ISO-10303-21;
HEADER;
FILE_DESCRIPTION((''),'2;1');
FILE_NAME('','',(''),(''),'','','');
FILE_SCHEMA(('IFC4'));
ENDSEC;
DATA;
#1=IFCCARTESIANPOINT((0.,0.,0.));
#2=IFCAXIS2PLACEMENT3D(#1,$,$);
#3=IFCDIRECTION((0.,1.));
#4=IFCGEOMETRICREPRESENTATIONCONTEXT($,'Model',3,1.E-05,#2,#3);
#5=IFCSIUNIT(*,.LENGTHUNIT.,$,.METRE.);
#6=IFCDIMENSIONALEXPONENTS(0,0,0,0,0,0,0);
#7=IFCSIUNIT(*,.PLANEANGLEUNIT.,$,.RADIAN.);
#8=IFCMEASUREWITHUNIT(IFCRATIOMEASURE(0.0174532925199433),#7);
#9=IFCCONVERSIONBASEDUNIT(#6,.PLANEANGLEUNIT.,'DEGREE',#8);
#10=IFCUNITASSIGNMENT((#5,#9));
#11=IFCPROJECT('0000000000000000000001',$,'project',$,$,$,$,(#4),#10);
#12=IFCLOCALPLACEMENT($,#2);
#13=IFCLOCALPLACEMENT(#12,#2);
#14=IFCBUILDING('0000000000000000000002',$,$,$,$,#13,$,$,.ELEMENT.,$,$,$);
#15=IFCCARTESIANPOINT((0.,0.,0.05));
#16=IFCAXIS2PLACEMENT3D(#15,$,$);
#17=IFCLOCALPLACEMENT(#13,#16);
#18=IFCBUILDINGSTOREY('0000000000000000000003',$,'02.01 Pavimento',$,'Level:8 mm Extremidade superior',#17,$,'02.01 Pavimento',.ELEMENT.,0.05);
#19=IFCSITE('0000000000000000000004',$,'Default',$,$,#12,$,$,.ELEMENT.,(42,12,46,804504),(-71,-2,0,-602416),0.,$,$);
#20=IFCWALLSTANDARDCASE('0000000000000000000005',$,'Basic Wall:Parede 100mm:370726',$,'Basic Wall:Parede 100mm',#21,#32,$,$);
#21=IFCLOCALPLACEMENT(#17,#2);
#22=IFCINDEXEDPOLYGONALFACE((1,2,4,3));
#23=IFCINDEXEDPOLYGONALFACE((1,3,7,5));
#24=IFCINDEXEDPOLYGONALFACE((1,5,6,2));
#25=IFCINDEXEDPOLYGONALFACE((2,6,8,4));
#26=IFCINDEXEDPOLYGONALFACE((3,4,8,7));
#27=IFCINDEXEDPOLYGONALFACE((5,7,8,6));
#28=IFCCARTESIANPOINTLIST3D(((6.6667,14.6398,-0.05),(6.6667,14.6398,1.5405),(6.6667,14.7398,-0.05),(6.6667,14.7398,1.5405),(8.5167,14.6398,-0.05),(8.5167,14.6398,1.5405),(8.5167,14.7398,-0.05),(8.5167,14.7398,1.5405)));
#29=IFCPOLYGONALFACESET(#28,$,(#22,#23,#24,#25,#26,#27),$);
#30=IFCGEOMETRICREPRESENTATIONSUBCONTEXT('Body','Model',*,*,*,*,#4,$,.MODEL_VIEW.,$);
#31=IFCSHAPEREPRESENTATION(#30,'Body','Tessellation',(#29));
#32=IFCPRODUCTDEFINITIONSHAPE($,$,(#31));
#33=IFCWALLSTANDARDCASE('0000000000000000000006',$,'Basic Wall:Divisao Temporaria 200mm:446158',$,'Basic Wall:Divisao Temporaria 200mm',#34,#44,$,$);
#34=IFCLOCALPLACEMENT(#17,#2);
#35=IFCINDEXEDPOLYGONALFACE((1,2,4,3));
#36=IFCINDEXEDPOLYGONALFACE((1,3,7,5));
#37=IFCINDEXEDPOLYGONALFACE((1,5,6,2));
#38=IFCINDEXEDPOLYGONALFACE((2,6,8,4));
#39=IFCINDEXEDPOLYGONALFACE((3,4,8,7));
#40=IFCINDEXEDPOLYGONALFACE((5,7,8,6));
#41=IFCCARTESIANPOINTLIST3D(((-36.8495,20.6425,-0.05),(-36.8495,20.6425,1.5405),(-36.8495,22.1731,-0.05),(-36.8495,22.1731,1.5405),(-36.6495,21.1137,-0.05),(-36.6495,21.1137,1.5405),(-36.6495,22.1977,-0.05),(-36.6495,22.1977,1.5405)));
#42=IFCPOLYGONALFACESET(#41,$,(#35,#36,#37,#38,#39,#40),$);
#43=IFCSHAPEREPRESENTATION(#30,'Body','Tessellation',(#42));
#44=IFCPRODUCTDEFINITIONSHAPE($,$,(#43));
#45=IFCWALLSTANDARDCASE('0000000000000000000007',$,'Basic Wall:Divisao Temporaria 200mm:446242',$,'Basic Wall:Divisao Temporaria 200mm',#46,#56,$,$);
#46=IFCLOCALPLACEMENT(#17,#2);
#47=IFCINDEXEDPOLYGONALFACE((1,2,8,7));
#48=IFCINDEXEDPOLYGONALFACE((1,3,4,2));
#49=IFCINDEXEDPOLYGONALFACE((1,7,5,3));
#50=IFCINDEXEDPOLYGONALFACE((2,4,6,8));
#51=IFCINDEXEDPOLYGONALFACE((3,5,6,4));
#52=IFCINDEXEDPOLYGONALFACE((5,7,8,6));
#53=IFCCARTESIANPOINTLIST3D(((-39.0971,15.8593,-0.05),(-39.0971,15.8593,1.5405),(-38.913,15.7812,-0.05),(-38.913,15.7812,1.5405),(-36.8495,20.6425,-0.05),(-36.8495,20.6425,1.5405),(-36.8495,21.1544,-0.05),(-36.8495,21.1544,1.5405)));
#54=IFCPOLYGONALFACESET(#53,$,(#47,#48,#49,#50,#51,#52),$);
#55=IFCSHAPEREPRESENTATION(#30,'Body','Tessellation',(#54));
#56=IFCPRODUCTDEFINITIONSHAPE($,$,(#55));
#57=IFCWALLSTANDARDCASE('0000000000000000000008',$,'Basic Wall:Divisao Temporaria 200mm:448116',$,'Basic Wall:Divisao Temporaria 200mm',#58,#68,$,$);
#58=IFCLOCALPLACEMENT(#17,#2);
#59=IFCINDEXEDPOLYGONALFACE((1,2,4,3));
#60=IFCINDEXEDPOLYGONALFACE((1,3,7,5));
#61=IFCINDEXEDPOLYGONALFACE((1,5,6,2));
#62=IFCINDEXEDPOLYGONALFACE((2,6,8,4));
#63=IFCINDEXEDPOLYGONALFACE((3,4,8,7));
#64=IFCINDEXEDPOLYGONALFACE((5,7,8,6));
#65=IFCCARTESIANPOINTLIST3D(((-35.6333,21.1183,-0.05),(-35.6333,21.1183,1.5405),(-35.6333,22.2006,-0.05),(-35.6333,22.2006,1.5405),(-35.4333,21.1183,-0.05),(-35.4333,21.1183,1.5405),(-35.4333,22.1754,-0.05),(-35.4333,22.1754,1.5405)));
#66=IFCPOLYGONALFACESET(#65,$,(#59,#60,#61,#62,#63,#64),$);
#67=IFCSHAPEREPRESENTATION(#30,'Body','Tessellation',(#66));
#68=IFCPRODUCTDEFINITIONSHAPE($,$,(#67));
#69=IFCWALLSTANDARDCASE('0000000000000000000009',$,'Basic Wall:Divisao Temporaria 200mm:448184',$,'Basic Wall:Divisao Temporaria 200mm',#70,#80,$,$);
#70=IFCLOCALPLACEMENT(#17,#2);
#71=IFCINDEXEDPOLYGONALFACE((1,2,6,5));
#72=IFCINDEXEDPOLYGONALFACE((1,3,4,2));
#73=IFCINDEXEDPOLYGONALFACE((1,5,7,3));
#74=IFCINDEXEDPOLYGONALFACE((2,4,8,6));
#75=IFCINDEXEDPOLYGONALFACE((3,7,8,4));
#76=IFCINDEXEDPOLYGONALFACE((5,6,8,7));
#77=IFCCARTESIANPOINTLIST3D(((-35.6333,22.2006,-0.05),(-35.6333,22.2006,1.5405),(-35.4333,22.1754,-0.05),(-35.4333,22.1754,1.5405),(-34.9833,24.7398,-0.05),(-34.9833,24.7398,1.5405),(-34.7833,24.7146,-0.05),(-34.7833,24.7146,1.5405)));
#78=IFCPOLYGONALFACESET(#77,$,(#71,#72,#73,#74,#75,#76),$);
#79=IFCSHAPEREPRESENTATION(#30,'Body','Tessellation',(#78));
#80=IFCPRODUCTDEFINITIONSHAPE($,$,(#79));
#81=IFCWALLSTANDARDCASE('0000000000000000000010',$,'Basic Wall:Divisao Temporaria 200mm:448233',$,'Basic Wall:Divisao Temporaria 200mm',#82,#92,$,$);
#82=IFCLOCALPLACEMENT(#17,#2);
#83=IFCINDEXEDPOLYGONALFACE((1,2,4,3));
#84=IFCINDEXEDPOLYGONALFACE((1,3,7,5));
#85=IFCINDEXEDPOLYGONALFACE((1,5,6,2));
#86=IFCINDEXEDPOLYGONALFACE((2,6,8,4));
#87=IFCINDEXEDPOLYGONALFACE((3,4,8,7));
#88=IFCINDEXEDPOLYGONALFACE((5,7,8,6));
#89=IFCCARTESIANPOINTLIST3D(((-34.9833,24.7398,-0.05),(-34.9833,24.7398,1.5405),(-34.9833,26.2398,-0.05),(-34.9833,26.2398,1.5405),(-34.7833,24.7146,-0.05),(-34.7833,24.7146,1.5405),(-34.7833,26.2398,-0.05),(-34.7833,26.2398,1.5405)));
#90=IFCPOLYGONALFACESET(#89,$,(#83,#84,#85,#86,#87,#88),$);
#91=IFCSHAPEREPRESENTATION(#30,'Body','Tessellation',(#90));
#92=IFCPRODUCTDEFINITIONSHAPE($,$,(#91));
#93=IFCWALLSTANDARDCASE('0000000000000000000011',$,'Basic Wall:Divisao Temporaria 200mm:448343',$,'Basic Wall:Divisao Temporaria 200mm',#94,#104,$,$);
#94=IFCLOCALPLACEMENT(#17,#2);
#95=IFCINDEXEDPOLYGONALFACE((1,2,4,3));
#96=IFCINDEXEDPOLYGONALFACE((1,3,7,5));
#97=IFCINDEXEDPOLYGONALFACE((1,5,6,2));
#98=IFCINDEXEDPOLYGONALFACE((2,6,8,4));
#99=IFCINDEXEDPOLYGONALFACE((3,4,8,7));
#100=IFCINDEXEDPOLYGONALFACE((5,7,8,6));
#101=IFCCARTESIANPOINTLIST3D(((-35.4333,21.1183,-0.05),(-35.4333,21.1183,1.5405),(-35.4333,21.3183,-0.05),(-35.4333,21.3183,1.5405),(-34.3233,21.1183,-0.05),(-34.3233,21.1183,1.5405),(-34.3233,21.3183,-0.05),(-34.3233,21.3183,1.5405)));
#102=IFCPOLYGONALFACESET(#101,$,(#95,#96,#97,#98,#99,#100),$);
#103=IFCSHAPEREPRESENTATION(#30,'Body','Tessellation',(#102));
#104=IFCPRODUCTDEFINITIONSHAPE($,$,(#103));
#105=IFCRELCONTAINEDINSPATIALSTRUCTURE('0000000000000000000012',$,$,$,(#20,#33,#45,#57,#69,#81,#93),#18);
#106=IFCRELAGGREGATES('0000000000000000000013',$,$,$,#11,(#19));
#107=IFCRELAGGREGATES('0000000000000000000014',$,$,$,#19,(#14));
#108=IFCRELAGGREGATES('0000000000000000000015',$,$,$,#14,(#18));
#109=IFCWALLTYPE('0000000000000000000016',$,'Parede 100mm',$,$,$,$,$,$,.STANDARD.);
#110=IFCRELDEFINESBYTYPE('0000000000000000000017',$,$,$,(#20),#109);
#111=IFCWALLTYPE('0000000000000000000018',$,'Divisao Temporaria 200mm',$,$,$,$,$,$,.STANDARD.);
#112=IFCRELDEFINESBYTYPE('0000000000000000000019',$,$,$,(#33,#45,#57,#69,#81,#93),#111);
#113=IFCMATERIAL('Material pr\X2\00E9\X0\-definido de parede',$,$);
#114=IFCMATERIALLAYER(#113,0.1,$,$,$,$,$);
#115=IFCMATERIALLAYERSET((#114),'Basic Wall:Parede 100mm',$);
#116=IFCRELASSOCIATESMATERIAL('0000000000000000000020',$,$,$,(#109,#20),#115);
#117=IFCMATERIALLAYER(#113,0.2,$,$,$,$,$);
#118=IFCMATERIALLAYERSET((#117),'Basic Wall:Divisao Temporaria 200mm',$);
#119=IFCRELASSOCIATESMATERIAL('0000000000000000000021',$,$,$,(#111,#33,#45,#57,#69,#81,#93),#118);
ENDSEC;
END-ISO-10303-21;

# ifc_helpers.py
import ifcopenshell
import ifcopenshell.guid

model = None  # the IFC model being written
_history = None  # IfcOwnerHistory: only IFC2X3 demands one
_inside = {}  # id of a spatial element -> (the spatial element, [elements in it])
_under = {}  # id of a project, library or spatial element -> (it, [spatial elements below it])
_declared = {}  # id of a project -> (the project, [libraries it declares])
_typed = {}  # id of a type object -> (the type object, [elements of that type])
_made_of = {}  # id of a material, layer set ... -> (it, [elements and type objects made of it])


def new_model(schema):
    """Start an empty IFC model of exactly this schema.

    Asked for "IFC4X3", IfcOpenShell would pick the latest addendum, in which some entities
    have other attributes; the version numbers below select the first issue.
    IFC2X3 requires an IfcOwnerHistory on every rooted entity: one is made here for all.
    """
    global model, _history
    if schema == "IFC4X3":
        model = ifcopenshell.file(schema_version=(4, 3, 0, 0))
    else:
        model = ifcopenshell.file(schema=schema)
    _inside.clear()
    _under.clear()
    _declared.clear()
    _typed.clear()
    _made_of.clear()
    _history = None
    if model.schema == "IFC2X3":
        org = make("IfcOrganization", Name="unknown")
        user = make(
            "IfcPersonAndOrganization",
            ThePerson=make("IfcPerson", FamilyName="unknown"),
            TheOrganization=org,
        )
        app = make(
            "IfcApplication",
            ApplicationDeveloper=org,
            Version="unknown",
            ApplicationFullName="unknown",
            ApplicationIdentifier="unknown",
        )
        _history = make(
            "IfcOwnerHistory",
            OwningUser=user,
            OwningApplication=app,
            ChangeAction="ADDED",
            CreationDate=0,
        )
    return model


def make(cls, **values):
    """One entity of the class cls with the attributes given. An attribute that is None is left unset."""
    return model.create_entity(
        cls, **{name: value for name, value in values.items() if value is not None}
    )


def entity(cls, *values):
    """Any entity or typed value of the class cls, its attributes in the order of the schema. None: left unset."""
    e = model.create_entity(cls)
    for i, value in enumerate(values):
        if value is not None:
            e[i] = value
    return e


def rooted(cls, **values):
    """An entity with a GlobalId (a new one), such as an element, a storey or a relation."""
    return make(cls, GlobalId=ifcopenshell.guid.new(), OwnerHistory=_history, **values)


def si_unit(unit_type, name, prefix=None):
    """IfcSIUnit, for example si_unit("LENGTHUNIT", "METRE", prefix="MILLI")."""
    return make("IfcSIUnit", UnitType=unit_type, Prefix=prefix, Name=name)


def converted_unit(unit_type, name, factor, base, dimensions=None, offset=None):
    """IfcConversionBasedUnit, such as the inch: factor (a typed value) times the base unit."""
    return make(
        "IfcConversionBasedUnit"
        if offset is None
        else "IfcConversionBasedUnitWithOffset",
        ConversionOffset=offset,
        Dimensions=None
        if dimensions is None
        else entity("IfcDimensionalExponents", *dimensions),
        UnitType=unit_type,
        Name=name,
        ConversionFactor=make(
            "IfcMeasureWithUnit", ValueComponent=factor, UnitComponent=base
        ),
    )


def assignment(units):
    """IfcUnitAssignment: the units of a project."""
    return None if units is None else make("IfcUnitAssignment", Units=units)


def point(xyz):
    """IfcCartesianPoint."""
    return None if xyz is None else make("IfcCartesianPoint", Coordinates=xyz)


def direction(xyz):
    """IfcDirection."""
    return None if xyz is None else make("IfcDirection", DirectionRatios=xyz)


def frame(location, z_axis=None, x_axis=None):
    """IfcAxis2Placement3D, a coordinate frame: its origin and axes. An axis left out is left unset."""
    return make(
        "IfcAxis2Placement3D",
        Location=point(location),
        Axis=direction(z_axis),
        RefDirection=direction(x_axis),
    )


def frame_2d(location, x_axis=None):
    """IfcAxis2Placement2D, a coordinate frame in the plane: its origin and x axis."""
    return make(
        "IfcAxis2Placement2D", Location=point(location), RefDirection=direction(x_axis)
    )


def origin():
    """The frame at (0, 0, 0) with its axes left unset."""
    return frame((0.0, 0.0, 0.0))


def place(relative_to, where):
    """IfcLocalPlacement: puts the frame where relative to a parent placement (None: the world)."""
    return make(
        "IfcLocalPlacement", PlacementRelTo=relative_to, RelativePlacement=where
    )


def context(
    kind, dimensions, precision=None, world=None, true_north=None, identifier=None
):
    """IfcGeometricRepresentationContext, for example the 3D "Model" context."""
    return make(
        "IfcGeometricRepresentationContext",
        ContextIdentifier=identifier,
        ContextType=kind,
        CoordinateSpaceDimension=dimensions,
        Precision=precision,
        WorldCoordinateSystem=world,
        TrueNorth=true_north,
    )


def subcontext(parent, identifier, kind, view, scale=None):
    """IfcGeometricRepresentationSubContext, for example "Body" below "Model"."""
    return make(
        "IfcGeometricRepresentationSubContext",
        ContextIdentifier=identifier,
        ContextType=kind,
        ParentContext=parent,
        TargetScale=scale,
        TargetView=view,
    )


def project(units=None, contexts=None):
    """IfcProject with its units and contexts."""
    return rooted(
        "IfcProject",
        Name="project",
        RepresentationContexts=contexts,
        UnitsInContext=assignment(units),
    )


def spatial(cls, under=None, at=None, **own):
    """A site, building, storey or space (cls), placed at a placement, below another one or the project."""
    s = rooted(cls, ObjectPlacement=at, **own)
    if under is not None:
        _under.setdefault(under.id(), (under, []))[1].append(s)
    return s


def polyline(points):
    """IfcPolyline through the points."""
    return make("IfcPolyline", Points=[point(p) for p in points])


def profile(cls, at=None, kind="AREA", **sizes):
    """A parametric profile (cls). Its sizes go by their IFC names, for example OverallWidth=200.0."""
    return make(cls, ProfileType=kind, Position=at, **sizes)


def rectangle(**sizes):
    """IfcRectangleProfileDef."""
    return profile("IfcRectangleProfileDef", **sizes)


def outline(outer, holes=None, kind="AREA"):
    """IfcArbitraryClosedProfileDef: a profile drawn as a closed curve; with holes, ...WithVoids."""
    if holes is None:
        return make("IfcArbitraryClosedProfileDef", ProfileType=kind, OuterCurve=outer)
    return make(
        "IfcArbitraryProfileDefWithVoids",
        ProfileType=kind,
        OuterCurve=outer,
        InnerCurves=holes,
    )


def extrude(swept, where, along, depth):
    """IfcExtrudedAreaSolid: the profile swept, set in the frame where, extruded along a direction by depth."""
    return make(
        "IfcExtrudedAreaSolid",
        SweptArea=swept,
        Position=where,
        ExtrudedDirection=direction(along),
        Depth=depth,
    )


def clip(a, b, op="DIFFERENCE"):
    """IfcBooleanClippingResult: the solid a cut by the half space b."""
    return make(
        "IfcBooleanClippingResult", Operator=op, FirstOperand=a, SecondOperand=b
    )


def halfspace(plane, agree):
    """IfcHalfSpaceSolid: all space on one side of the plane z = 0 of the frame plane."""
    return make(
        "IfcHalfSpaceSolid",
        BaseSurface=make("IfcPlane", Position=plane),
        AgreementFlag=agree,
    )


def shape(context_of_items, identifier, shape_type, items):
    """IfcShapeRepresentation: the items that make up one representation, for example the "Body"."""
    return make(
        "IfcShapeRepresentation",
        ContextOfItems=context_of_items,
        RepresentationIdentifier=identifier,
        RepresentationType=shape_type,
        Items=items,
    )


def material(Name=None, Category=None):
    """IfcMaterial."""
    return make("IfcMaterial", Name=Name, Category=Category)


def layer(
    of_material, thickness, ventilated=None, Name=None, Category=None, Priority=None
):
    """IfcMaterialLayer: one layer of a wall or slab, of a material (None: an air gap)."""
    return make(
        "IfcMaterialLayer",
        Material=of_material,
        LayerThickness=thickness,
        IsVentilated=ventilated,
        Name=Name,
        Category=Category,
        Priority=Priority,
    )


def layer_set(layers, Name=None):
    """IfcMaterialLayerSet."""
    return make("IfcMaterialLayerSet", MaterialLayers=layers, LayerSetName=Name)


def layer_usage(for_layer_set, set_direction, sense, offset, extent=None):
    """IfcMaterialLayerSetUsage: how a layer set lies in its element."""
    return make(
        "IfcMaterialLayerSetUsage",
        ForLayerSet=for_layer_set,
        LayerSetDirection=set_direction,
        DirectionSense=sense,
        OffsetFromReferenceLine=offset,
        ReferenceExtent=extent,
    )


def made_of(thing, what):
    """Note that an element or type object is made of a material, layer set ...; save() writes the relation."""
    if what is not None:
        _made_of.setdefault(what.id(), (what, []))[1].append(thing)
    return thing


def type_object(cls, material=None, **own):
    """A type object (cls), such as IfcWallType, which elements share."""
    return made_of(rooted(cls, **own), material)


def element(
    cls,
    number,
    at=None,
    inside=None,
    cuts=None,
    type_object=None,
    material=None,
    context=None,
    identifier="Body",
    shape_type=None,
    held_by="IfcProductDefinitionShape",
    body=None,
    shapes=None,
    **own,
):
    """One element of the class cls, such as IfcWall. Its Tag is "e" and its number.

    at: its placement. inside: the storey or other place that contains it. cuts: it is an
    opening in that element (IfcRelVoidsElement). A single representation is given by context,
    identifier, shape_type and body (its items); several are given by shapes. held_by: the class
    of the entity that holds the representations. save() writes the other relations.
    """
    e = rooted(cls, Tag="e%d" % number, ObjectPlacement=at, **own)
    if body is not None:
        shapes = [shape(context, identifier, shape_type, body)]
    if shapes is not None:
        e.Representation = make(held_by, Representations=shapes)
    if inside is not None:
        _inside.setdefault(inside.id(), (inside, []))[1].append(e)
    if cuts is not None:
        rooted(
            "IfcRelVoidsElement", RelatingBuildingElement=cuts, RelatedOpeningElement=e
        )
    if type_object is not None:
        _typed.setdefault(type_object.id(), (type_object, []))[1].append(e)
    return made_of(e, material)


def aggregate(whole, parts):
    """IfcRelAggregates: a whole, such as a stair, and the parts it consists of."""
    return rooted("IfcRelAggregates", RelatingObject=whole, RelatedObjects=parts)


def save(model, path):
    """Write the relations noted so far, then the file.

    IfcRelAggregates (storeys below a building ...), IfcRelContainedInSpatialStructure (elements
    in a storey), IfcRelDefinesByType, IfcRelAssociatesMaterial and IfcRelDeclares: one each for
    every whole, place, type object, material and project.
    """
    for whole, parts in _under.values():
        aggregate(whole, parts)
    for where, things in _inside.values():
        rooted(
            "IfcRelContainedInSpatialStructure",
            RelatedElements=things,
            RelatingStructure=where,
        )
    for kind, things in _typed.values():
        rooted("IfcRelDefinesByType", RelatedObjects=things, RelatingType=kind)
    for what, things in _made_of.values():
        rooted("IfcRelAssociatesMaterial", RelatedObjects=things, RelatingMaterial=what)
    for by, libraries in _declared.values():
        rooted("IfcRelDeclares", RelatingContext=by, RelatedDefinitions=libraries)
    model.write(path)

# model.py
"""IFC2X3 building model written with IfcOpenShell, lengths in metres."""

from ifc_helpers import new_model, entity, si_unit, converted_unit, direction, frame, frame_2d, origin, place, context, subcontext, project, spatial, polyline, rectangle, outline, extrude, clip, halfspace, material, layer, layer_set, layer_usage, type_object, element, save


model = new_model("IFC2X3")

# Units and contexts
model_context = context("Model", 3, precision=1e-05, world=origin(), true_north=direction((0.0, 1.0)))
body_context = subcontext(model_context, "Body", "Model", "MODEL_VIEW")
ifc_project = project(units=[si_unit("LENGTHUNIT", "METRE"), converted_unit("PLANEANGLEUNIT", "DEGREE", entity("IfcRatioMeasure", 0.0174532925199433), si_unit("PLANEANGLEUNIT", "RADIAN"), dimensions=[0, 0, 0, 0, 0, 0, 0])], contexts=[model_context])

# Site, building, storey
site_placement = place(None, origin())
site = spatial("IfcSite", under=ifc_project, at=site_placement, Name="Default", CompositionType="ELEMENT", RefLatitude=(42, 12, 46, 804504), RefLongitude=(-71, -2, 0, -602416), RefElevation=0.0)
building_placement = place(site_placement, origin())
building = spatial("IfcBuilding", under=site, at=building_placement, CompositionType="ELEMENT")
storey_placement = place(building_placement, frame((0.0, 0.0, 0.05)))
storey = spatial("IfcBuildingStorey", under=building, at=storey_placement, Name="02.01 Pavimento", ObjectType="Level:8 mm Extremidade superior", LongName="02.01 Pavimento", CompositionType="ELEMENT", Elevation=0.05)

# Shared definitions
ifc_material = material(Name="Material pré-definido de parede")

# Walls
ifc_layer_1 = layer(ifc_material, 0.1)
ifc_layer_set_1 = layer_set([ifc_layer_1], Name="Basic Wall:Parede 100mm")
ifc_layer_usage_1 = layer_usage(ifc_layer_set_1, "AXIS2", "POSITIVE", -0.05)
wall_type_1 = type_object("IfcWallType", Name="Parede 100mm", PredefinedType="STANDARD", material=ifc_layer_set_1)
wall_1_placement = place(storey_placement, frame((6.6667, 14.6898, -0.05)))
element("IfcWallStandardCase", 1, at=wall_1_placement, inside=storey, type_object=wall_type_1, material=ifc_layer_usage_1, Name="Basic Wall:Parede 100mm:370726", ObjectType="Basic Wall:Parede 100mm", context=body_context, shape_type="Clipping", body=[
    clip(extrude(rectangle(XDim=1.85, YDim=0.1, at=frame_2d((0.925, 0.0), x_axis=(-1.0, 0.0))), origin(), (0.0, 0.0, 1.0), 1.5905), halfspace(frame((0.0, 0.0, -0.05)), True)),
])
ifc_layer_2 = layer(ifc_material, 0.2)
ifc_layer_set_2 = layer_set([ifc_layer_2], Name="Basic Wall:Divisao Temporaria 200mm")
ifc_layer_usage_2 = layer_usage(ifc_layer_set_2, "AXIS2", "NEGATIVE", 0.1)
wall_type_2 = type_object("IfcWallType", Name="Divisao Temporaria 200mm", PredefinedType="STANDARD", material=ifc_layer_set_2)
wall_2_placement = place(storey_placement, frame((-36.7495, 22.1977, -0.05), z_axis=(0.0, 0.0, 1.0), x_axis=(0.0, -1.0, 0.0)))
element("IfcWallStandardCase", 2, at=wall_2_placement, inside=storey, type_object=wall_type_2, material=ifc_layer_usage_2, Name="Basic Wall:Divisao Temporaria 200mm:446158", ObjectType="Basic Wall:Divisao Temporaria 200mm", context=body_context, shape_type="Clipping", body=[
    clip(extrude(outline(polyline([(1.5552, -0.1), (1.084, 0.1), (0.0, 0.1), (0.0246, -0.1), (1.0433, -0.1), (1.5552, -0.1)])), origin(), (0.0, 0.0, 1.0), 1.5905), halfspace(frame((0.0, 0.0, -0.05)), True)),
])
ifc_layer_usage_3 = layer_usage(ifc_layer_set_2, "AXIS2", "NEGATIVE", 0.1)
wall_3_placement = place(storey_placement, frame((-36.7574, 21.1153, -0.05), z_axis=(0.0, 0.0, 1.0), x_axis=(-0.390731, -0.920505, 0.0)))
element("IfcWallStandardCase", 3, at=wall_3_placement, inside=storey, type_object=wall_type_2, material=ifc_layer_usage_3, Name="Basic Wall:Divisao Temporaria 200mm:446242", ObjectType="Basic Wall:Divisao Temporaria 200mm", context=body_context, shape_type="Clipping", body=[
    clip(extrude(outline(polyline([(5.7523, -0.1), (5.7523, 0.1), (0.4712, 0.1), (0.0, -0.1), (3.2496, -0.1), (3.4496, -0.1), (5.7523, -0.1)])), origin(), (0.0, 0.0, 1.0), 1.5905), halfspace(frame((0.0, 0.0, -0.05)), True)),
])
ifc_layer_usage_4 = layer_usage(ifc_layer_set_2, "AXIS2", "NEGATIVE", 0.1)
wall_4_placement = place(storey_placement, frame((-35.5333, 21.1183, -0.05), z_axis=(0.0, 0.0, 1.0), x_axis=(0.0, 1.0, 0.0)))
element("IfcWallStandardCase", 4, at=wall_4_placement, inside=storey, type_object=wall_type_2, material=ifc_layer_usage_4, Name="Basic Wall:Divisao Temporaria 200mm:448116", ObjectType="Basic Wall:Divisao Temporaria 200mm", context=body_context, shape_type="Clipping", body=[
    clip(extrude(outline(polyline([(1.0571, -0.1), (1.0823, 0.1), (0.0, 0.1), (0.0, -0.1), (0.2, -0.1), (1.0571, -0.1)])), origin(), (0.0, 0.0, 1.0), 1.5905), halfspace(frame((0.0, 0.0, -0.05)), True)),
])
ifc_layer_usage_5 = layer_usage(ifc_layer_set_2, "AXIS2", "NEGATIVE", 0.1)
wall_5_placement = place(storey_placement, frame((-35.5364, 22.1758, -0.05), z_axis=(0.0, 0.0, 1.0), x_axis=(0.247984, 0.968764, 0.0)))
element("IfcWallStandardCase", 5, at=wall_5_placement, inside=storey, type_object=wall_type_2, material=ifc_layer_usage_5, Name="Basic Wall:Divisao Temporaria 200mm:448184", ObjectType="Basic Wall:Divisao Temporaria 200mm", context=body_context, shape_type="Clipping", body=[
    clip(extrude(outline(polyline([(2.6463, -0.1), (2.6211, 0.1), (0.0, 0.1), (0.0252, -0.1), (2.6463, -0.1)])), origin(), (0.0, 0.0, 1.0), 1.5905), halfspace(frame((0.0, 0.0, -0.05)), True)),
])
ifc_layer_usage_6 = layer_usage(ifc_layer_set_2, "AXIS2", "NEGATIVE", 0.1)
wall_6_placement = place(storey_placement, frame((-34.8833, 24.7146, -0.05), z_axis=(0.0, 0.0, 1.0), x_axis=(0.0, 1.0, 0.0)))
element("IfcWallStandardCase", 6, at=wall_6_placement, inside=storey, type_object=wall_type_2, material=ifc_layer_usage_6, Name="Basic Wall:Divisao Temporaria 200mm:448233", ObjectType="Basic Wall:Divisao Temporaria 200mm", context=body_context, shape_type="Clipping", body=[
    clip(extrude(outline(polyline([(1.5252, -0.1), (1.5252, 0.1), (0.0252, 0.1), (0.0, -0.1), (1.5252, -0.1)])), origin(), (0.0, 0.0, 1.0), 1.5905), halfspace(frame((0.0, 0.0, -0.05)), True)),
])
ifc_layer_usage_7 = layer_usage(ifc_layer_set_2, "AXIS2", "POSITIVE", -0.1)
wall_7_placement = place(storey_placement, frame((-35.4333, 21.2183, -0.05)))
element("IfcWallStandardCase", 7, at=wall_7_placement, inside=storey, type_object=wall_type_2, material=ifc_layer_usage_7, Name="Basic Wall:Divisao Temporaria 200mm:448343", ObjectType="Basic Wall:Divisao Temporaria 200mm", context=body_context, shape_type="Clipping", body=[
    clip(extrude(rectangle(XDim=1.11, YDim=0.2, at=frame_2d((0.555, 0.0), x_axis=(-1.0, 0.0))), origin(), (0.0, 0.0, 1.0), 1.5905), halfspace(frame((0.0, 0.0, -0.05)), True)),
])

save(model, "model.ifc")
